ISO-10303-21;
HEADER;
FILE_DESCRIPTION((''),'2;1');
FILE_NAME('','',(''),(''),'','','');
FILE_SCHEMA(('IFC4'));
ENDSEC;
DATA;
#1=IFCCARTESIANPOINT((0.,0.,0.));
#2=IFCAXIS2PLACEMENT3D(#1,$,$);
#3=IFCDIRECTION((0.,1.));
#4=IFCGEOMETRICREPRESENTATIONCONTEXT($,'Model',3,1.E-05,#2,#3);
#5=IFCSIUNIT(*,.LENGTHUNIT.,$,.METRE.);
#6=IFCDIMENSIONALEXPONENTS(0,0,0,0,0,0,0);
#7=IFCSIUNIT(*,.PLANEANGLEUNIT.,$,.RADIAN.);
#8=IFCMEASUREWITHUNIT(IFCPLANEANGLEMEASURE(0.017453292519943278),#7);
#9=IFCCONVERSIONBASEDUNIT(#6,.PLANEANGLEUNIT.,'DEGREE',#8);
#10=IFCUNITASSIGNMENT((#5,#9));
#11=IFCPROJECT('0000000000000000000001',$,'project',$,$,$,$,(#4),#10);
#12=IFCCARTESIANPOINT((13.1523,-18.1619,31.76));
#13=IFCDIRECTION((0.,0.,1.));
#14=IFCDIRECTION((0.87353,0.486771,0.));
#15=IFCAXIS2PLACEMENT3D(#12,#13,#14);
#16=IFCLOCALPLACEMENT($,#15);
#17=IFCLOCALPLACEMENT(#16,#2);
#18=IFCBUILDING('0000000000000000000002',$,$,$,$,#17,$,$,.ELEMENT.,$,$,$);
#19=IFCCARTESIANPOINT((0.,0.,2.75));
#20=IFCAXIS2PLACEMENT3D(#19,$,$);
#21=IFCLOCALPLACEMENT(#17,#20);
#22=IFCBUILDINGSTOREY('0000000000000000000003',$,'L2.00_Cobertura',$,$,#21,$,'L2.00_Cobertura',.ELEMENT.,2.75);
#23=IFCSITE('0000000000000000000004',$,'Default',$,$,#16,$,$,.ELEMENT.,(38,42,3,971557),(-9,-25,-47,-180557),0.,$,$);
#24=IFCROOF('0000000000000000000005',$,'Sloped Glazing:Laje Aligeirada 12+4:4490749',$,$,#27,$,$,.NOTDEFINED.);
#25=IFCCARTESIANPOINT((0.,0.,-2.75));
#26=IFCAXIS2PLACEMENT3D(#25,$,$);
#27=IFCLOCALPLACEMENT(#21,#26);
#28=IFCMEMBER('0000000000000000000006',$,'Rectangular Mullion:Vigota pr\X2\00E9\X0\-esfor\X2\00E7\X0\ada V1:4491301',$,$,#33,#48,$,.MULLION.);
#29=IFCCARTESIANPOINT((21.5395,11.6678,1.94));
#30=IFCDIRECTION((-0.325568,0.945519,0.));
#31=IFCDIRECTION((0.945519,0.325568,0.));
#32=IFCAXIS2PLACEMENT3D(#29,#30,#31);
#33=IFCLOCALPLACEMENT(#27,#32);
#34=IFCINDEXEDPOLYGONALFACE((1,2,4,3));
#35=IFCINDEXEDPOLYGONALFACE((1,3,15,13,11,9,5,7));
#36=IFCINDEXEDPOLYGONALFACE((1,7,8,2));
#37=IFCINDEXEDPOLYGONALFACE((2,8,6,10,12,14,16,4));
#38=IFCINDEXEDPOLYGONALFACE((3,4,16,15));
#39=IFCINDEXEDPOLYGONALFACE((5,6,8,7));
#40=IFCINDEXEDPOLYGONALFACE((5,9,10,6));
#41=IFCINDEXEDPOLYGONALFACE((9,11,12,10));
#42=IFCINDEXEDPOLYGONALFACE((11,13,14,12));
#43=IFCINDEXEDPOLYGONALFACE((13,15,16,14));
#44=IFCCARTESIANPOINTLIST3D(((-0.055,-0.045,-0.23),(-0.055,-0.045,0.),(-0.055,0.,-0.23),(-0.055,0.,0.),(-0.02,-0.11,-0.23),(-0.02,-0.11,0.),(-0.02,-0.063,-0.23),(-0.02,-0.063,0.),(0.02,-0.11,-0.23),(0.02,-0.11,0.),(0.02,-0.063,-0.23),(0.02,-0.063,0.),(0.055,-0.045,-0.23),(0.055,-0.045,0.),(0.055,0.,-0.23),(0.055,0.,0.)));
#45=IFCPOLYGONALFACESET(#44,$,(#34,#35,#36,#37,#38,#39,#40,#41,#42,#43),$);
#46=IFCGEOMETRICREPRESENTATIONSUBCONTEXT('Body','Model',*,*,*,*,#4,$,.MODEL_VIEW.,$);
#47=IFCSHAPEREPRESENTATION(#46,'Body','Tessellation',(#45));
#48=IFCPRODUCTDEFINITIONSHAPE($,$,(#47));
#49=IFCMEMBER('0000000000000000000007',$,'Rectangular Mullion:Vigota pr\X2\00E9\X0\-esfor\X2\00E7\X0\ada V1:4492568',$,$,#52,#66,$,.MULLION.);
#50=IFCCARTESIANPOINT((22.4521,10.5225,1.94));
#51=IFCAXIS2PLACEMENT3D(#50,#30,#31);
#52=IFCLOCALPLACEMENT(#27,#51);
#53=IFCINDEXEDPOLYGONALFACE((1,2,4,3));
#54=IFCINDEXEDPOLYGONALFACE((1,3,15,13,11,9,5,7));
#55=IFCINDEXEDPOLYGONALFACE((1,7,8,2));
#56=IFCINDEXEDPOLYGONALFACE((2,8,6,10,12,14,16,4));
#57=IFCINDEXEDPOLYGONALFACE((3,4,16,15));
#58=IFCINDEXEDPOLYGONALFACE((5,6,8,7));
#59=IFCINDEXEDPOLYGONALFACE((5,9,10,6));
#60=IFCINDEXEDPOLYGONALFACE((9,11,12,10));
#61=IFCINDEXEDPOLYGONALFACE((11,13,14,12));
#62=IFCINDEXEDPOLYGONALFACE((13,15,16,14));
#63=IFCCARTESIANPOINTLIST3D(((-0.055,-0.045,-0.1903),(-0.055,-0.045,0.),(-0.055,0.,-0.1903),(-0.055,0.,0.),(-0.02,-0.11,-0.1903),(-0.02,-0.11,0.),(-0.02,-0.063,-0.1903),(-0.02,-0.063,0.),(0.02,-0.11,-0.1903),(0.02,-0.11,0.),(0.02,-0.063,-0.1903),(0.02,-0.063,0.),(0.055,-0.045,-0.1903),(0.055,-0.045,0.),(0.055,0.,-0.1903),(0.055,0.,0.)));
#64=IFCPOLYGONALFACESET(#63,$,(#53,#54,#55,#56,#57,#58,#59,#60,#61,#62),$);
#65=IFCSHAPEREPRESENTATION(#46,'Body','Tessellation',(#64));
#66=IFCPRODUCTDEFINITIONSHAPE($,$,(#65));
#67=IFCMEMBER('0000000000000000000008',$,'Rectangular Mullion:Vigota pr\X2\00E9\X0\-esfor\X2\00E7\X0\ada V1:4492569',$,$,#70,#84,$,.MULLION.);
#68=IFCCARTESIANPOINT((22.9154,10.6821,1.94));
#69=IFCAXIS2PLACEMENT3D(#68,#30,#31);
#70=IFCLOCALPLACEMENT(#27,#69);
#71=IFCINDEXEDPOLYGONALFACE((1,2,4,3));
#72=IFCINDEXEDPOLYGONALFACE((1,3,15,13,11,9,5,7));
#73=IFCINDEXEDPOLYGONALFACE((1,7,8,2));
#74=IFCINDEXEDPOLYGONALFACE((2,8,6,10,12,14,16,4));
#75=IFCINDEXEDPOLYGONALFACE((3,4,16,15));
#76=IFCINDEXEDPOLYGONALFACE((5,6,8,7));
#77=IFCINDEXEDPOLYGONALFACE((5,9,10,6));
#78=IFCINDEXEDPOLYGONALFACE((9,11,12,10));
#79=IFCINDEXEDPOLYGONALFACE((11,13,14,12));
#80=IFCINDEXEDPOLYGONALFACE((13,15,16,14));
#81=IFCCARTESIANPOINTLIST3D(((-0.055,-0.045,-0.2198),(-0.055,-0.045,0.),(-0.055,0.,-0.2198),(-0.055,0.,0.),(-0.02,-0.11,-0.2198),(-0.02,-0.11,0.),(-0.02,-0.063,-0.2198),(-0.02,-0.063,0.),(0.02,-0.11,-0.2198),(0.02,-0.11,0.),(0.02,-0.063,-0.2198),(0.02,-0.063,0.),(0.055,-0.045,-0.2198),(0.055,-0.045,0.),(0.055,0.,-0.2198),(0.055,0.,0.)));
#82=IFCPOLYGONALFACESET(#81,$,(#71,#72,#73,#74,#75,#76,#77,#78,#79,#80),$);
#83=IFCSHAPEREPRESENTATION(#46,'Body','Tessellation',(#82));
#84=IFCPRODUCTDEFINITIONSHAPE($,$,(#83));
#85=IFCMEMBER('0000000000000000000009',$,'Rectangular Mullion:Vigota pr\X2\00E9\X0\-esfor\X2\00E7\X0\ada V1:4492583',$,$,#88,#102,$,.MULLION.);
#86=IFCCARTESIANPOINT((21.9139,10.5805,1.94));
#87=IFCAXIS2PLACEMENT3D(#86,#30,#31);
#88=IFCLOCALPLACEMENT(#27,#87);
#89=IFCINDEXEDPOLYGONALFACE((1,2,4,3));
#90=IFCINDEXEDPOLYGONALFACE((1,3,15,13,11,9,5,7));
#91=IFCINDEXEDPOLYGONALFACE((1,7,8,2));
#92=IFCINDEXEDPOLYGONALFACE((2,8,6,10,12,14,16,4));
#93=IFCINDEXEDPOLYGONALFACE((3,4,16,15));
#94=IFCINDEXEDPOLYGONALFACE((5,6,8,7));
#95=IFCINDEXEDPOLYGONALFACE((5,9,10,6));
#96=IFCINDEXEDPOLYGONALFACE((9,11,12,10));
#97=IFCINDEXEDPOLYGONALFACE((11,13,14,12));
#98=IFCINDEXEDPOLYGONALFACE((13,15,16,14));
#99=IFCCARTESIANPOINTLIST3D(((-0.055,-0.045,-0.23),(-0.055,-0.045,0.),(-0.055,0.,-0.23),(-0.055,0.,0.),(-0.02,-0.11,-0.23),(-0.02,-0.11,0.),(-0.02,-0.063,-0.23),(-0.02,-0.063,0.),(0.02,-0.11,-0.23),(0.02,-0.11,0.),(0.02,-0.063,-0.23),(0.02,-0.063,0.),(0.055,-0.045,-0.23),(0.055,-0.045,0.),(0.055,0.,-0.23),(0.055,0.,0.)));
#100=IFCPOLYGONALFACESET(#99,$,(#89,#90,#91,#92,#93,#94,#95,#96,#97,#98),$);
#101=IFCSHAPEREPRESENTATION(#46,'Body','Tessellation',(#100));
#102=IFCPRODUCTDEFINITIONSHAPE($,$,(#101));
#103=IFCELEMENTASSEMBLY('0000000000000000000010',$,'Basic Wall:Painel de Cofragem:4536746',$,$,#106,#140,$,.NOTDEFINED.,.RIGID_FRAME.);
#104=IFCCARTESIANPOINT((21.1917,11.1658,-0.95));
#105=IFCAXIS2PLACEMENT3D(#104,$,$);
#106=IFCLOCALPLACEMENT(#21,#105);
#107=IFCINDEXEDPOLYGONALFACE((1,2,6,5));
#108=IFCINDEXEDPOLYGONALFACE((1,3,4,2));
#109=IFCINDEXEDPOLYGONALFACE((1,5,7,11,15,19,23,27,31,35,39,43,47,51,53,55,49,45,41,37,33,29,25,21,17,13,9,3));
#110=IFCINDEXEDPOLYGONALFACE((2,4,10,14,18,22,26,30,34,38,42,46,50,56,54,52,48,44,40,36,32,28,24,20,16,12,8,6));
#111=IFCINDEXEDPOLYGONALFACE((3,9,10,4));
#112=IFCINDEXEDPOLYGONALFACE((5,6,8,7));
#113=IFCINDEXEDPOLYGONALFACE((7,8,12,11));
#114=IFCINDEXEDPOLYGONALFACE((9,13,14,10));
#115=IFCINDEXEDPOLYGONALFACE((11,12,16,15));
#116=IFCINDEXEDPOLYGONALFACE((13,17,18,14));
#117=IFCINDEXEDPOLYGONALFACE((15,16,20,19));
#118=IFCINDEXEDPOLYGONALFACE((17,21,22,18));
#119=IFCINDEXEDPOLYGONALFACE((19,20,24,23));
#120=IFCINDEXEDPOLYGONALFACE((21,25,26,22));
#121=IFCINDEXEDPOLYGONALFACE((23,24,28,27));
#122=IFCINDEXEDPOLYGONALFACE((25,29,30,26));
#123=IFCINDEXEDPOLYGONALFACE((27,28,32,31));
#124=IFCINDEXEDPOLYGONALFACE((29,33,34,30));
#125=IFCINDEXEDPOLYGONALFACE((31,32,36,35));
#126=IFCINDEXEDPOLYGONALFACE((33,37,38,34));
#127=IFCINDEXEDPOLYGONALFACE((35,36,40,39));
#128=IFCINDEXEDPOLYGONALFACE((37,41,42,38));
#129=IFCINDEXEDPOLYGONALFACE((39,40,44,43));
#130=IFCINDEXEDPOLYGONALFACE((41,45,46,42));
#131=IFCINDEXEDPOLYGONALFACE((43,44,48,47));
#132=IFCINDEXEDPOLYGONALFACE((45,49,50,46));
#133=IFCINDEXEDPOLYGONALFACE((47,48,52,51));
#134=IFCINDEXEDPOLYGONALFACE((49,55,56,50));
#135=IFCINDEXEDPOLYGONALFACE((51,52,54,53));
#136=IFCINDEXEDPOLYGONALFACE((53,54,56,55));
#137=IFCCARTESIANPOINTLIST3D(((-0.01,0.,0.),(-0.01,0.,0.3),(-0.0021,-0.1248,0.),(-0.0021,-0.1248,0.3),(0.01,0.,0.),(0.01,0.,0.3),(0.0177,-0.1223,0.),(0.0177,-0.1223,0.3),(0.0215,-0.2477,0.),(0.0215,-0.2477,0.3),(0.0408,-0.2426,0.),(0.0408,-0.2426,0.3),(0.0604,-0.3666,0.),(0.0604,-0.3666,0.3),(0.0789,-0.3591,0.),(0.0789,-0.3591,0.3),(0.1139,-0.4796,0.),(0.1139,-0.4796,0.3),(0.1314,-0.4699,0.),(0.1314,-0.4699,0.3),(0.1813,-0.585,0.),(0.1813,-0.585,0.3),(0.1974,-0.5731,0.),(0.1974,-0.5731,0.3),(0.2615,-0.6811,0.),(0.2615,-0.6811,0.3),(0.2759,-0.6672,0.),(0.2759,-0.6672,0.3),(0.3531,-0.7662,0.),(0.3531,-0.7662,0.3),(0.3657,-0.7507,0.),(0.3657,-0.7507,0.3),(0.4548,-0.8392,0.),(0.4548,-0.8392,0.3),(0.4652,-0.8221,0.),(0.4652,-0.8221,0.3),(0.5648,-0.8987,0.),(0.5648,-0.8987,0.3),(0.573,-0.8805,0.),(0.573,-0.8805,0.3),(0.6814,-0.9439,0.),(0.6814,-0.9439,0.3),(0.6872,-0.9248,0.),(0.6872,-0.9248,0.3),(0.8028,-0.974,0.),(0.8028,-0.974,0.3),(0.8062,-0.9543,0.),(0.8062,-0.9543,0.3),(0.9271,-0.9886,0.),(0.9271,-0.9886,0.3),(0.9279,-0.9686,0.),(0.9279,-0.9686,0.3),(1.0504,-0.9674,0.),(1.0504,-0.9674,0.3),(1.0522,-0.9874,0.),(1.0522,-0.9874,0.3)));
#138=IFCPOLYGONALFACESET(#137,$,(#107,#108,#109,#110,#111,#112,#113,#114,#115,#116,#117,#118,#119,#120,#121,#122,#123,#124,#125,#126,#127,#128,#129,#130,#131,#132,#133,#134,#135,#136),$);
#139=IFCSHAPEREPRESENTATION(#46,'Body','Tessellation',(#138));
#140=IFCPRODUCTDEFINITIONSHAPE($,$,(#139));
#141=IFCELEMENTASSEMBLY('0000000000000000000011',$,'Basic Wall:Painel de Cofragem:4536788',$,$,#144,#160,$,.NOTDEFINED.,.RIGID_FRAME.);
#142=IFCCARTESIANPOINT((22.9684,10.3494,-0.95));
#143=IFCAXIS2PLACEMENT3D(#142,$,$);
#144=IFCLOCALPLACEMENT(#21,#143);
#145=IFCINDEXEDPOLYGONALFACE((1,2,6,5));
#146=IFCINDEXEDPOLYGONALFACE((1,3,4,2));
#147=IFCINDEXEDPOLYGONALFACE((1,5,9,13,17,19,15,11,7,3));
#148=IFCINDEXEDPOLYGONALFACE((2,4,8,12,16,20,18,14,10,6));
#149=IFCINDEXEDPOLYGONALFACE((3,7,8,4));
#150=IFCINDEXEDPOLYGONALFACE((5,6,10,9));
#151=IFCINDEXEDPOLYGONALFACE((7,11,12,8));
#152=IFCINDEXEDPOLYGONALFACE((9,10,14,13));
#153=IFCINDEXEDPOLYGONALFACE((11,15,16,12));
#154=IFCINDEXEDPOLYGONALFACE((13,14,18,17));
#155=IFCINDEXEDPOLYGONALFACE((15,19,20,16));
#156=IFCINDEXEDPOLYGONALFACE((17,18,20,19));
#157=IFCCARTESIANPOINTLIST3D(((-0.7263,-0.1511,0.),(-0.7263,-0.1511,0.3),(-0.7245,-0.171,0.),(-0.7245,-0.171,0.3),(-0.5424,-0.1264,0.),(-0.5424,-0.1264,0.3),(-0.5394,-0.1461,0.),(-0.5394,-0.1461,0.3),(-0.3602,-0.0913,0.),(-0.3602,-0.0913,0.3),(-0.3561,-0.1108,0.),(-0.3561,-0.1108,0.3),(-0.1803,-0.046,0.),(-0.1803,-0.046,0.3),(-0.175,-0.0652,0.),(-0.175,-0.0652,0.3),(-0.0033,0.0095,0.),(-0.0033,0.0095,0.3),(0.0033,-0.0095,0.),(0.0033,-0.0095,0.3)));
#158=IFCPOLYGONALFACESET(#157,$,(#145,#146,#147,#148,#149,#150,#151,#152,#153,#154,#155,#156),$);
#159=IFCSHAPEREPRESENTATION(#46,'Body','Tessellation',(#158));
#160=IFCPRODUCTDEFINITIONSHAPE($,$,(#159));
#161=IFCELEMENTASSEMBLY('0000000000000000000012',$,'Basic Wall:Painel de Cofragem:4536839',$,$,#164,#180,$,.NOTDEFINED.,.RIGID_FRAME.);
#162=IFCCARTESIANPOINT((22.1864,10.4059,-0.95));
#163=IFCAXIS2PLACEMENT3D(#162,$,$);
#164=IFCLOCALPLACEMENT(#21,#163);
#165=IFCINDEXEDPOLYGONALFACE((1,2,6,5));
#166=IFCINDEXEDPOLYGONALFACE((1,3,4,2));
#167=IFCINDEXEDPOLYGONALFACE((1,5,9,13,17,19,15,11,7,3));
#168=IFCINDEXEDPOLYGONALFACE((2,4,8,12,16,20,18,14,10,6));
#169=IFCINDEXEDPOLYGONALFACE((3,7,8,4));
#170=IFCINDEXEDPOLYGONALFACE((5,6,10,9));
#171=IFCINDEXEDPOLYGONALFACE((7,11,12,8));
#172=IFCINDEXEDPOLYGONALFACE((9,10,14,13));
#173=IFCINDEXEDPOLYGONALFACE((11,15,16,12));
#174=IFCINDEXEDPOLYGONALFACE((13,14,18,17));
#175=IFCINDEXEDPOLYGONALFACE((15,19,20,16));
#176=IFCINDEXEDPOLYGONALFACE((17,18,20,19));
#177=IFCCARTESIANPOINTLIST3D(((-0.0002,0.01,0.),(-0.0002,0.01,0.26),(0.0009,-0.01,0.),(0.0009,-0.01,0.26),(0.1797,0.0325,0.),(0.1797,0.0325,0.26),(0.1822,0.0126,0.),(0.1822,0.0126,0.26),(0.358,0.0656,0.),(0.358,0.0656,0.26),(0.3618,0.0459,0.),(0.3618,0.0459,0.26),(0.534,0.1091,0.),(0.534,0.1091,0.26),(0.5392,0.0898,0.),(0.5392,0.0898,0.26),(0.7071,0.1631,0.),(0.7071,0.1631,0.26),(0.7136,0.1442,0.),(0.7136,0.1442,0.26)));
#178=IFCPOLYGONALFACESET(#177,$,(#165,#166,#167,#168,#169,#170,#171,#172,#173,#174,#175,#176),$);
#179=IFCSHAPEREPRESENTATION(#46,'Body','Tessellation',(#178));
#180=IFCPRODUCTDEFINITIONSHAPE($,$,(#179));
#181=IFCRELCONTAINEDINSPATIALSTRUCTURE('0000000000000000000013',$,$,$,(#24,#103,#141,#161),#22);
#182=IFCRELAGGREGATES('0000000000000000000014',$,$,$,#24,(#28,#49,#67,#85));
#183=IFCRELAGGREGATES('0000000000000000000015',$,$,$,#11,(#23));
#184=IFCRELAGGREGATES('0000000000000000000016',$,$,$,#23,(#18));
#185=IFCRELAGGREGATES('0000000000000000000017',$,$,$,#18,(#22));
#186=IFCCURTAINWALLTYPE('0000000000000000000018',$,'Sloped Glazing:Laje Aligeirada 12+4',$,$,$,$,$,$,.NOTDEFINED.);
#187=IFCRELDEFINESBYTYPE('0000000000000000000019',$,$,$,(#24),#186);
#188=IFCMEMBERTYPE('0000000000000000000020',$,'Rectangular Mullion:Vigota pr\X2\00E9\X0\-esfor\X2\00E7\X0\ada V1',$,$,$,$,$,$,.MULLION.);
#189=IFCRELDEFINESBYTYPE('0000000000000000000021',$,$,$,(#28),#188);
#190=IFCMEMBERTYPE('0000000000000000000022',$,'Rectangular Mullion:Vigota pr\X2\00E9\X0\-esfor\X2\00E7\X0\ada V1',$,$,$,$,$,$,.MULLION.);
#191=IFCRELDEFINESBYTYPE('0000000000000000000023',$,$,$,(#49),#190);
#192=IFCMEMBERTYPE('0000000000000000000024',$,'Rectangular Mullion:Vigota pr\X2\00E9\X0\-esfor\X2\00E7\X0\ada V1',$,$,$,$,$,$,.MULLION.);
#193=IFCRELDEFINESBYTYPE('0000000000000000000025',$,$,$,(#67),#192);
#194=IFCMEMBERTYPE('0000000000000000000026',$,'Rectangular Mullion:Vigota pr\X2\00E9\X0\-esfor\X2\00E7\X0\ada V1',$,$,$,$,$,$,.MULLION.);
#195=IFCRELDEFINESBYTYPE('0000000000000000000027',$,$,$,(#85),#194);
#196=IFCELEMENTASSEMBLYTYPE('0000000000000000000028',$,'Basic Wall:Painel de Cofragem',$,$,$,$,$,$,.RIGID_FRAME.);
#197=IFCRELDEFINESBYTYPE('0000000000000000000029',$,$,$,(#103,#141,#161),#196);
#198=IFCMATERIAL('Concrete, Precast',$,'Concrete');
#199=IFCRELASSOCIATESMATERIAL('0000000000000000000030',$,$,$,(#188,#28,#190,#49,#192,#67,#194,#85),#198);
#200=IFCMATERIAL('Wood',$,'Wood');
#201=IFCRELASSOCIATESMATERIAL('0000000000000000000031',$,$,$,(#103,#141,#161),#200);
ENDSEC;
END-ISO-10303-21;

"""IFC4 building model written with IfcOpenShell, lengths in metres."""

from ifc_helpers import new_model, entity, si_unit, converted_unit, direction, frame, origin, place, context, subcontext, project, spatial, line, arc, indexed_curve, outline, extrude, source, transform, mapped, material, type_object, type_shapes, element, aggregate, save


model = new_model("IFC4")

# Units and contexts
model_context = context("Model", 3, precision=1e-05, world=origin(), true_north=direction((0.0, 1.0)))
body_context = subcontext(model_context, "Body", "Model", "MODEL_VIEW")
ifc_project = project(units=[si_unit("LENGTHUNIT", "METRE"), converted_unit("PLANEANGLEUNIT", "DEGREE", entity("IfcPlaneAngleMeasure", 0.017453292519943278), si_unit("PLANEANGLEUNIT", "RADIAN"), dimensions=[0, 0, 0, 0, 0, 0, 0])], contexts=[model_context])

# Site, building, storey
site_placement = place(None, frame((13.1523, -18.1619, 31.76), z_axis=(0.0, 0.0, 1.0), x_axis=(0.87353, 0.486771, 0.0)))
site = spatial("IfcSite", under=ifc_project, at=site_placement, Name="Default", CompositionType="ELEMENT", RefLatitude=(38, 42, 3, 971557), RefLongitude=(-9, -25, -47, -180557), RefElevation=0.0)
building_placement = place(site_placement, origin())
building = spatial("IfcBuilding", under=site, at=building_placement, CompositionType="ELEMENT")
storey_placement = place(building_placement, frame((0.0, 0.0, 2.75)))
storey = spatial("IfcBuildingStorey", under=building, at=storey_placement, Name="L2.00_Cobertura", LongName="L2.00_Cobertura", CompositionType="ELEMENT", Elevation=2.75)

# Roof, members
curtain_wall_type = type_object("IfcCurtainWallType", Name="Sloped Glazing:Laje Aligeirada 12+4", PredefinedType="NOTDEFINED")
roof_placement = place(storey_placement, frame((0.0, 0.0, -2.75)))
roof = element("IfcRoof", 1, at=roof_placement, inside=storey, type_object=curtain_wall_type, Name="Sloped Glazing:Laje Aligeirada 12+4:4490749", PredefinedType="NOTDEFINED")
ifc_material_1 = material(Name="Concrete, Precast", Category="Concrete")
member_type_1 = type_object("IfcMemberType", Name="Rectangular Mullion:Vigota pré-esforçada V1", PredefinedType="MULLION", material=ifc_material_1)
shared_shape_1 = source(origin(), body_context, "Body", "SweptSolid", [
    extrude(outline(indexed_curve([(-0.055, -0.0545), (0.055, -0.0545), (0.055, -0.0095), (0.02, 0.0085), (0.02, 0.0555), (-0.02, 0.0555), (-0.02, 0.0085), (-0.055, -0.0095), (-0.055, -0.0545)], self_intersect=False)), frame((0.0, -0.0545, -0.23), z_axis=(0.0, 0.0, 1.0), x_axis=(-1.0, 0.0, 0.0)), (0.0, 0.0, 1.0), 0.23),
])
type_shapes(member_type_1, [shared_shape_1])
member_1_placement = place(roof_placement, frame((21.5395, 11.6678, 1.94), z_axis=(-0.325568, 0.945519, 0.0), x_axis=(0.945519, 0.325568, 0.0)))
member_1 = element("IfcMember", 2, at=member_1_placement, type_object=member_type_1, material=ifc_material_1, Name="Rectangular Mullion:Vigota pré-esforçada V1:4491301", PredefinedType="MULLION", context=body_context, shape_type="MappedRepresentation", body=[
    mapped(shared_shape_1, transform((0.0, 0.0, 0.0), scale=1.0)),
])
member_type_2 = type_object("IfcMemberType", Name="Rectangular Mullion:Vigota pré-esforçada V1", PredefinedType="MULLION", material=ifc_material_1)
shared_shape_2 = source(origin(), body_context, "Body", "SweptSolid", [
    extrude(outline(indexed_curve([(-0.055, -0.0545), (0.055, -0.0545), (0.055, -0.0095), (0.02, 0.0085), (0.02, 0.0555), (-0.02, 0.0555), (-0.02, 0.0085), (-0.055, -0.0095), (-0.055, -0.0545)], self_intersect=False)), frame((0.0, -0.0545, -0.1903), z_axis=(0.0, 0.0, 1.0), x_axis=(-1.0, 0.0, 0.0)), (0.0, 0.0, 1.0), 0.1903),
])
type_shapes(member_type_2, [shared_shape_2])
member_2_placement = place(roof_placement, frame((22.4521, 10.5225, 1.94), z_axis=(-0.325568, 0.945519, 0.0), x_axis=(0.945519, 0.325568, 0.0)))
member_2 = element("IfcMember", 3, at=member_2_placement, type_object=member_type_2, material=ifc_material_1, Name="Rectangular Mullion:Vigota pré-esforçada V1:4492568", PredefinedType="MULLION", context=body_context, shape_type="MappedRepresentation", body=[
    mapped(shared_shape_2, transform((0.0, 0.0, 0.0), scale=1.0)),
])
member_type_3 = type_object("IfcMemberType", Name="Rectangular Mullion:Vigota pré-esforçada V1", PredefinedType="MULLION", material=ifc_material_1)
shared_shape_3 = source(origin(), body_context, "Body", "SweptSolid", [
    extrude(outline(indexed_curve([(-0.055, -0.0545), (0.055, -0.0545), (0.055, -0.0095), (0.02, 0.0085), (0.02, 0.0555), (-0.02, 0.0555), (-0.02, 0.0085), (-0.055, -0.0095), (-0.055, -0.0545)], self_intersect=False)), frame((0.0, -0.0545, -0.2198), z_axis=(0.0, 0.0, 1.0), x_axis=(-1.0, 0.0, 0.0)), (0.0, 0.0, 1.0), 0.2198),
])
type_shapes(member_type_3, [shared_shape_3])
member_3_placement = place(roof_placement, frame((22.9154, 10.6821, 1.94), z_axis=(-0.325568, 0.945519, 0.0), x_axis=(0.945519, 0.325568, 0.0)))
member_3 = element("IfcMember", 4, at=member_3_placement, type_object=member_type_3, material=ifc_material_1, Name="Rectangular Mullion:Vigota pré-esforçada V1:4492569", PredefinedType="MULLION", context=body_context, shape_type="MappedRepresentation", body=[
    mapped(shared_shape_3, transform((0.0, 0.0, 0.0), scale=1.0)),
])
member_type_4 = type_object("IfcMemberType", Name="Rectangular Mullion:Vigota pré-esforçada V1", PredefinedType="MULLION", material=ifc_material_1)
shared_shape_4 = source(origin(), body_context, "Body", "SweptSolid", [
    extrude(outline(indexed_curve([(-0.055, -0.0545), (0.055, -0.0545), (0.055, -0.0095), (0.02, 0.0085), (0.02, 0.0555), (-0.02, 0.0555), (-0.02, 0.0085), (-0.055, -0.0095), (-0.055, -0.0545)], self_intersect=False)), frame((0.0, -0.0545, -0.23), z_axis=(0.0, 0.0, 1.0), x_axis=(-1.0, 0.0, 0.0)), (0.0, 0.0, 1.0), 0.23),
])
type_shapes(member_type_4, [shared_shape_4])
member_4_placement = place(roof_placement, frame((21.9139, 10.5805, 1.94), z_axis=(-0.325568, 0.945519, 0.0), x_axis=(0.945519, 0.325568, 0.0)))
member_4 = element("IfcMember", 5, at=member_4_placement, type_object=member_type_4, material=ifc_material_1, Name="Rectangular Mullion:Vigota pré-esforçada V1:4492583", PredefinedType="MULLION", context=body_context, shape_type="MappedRepresentation", body=[
    mapped(shared_shape_4, transform((0.0, 0.0, 0.0), scale=1.0)),
])

# Shared definitions
ifc_material_2 = material(Name="Wood", Category="Wood")

aggregate(roof, [member_1, member_2, member_3, member_4])

# Element assemblies
element_assembly_type = type_object("IfcElementAssemblyType", Name="Basic Wall:Painel de Cofragem", PredefinedType="RIGID_FRAME")
assembly_1_placement = place(storey_placement, frame((21.1917, 11.1658, -0.95)))
element("IfcElementAssembly", 6, at=assembly_1_placement, inside=storey, type_object=element_assembly_type, material=ifc_material_2, Name="Basic Wall:Painel de Cofragem:4536746", AssemblyPlace="NOTDEFINED", PredefinedType="RIGID_FRAME", context=body_context, shape_type="SweptSolid", body=[
    extrude(outline(indexed_curve([(1.0504, -0.9674), (0.3195, -0.7103), (0.01, 0.0), (-0.01, 0.0), (0.306, -0.7251), (1.0522, -0.9874)], segments=[arc(1, 2, 3), line(3, 4), arc(4, 5, 6), line(6, 1)], self_intersect=False)), origin(), (0.0, 0.0, 1.0), 0.3),
])
assembly_2_placement = place(storey_placement, frame((22.9684, 10.3494, -0.95)))
element("IfcElementAssembly", 7, at=assembly_2_placement, inside=storey, type_object=element_assembly_type, material=ifc_material_2, Name="Basic Wall:Painel de Cofragem:4536788", AssemblyPlace="NOTDEFINED", PredefinedType="RIGID_FRAME", context=body_context, shape_type="SweptSolid", body=[
    extrude(outline(indexed_curve([(-0.7245, -0.171), (-0.3561, -0.1108), (0.0033, -0.0095), (-0.0033, 0.0095), (-0.3602, -0.0913), (-0.7263, -0.1511)], segments=[arc(1, 2, 3), line(3, 4), arc(4, 5, 6), line(6, 1)], self_intersect=False)), origin(), (0.0, 0.0, 1.0), 0.3),
])
assembly_3_placement = place(storey_placement, frame((22.1864, 10.4059, -0.95)))
element("IfcElementAssembly", 8, at=assembly_3_placement, inside=storey, type_object=element_assembly_type, material=ifc_material_2, Name="Basic Wall:Painel de Cofragem:4536839", AssemblyPlace="NOTDEFINED", PredefinedType="RIGID_FRAME", context=body_context, shape_type="SweptSolid", body=[
    extrude(outline(indexed_curve([(0.7071, 0.1631), (0.358, 0.0656), (-0.0002, 0.01), (0.0009, -0.01), (0.3618, 0.0459), (0.7136, 0.1442)], segments=[arc(1, 2, 3), line(3, 4), arc(4, 5, 6), line(6, 1)], self_intersect=False)), origin(), (0.0, 0.0, 1.0), 0.26),
])

save(model, "model.ifc")
